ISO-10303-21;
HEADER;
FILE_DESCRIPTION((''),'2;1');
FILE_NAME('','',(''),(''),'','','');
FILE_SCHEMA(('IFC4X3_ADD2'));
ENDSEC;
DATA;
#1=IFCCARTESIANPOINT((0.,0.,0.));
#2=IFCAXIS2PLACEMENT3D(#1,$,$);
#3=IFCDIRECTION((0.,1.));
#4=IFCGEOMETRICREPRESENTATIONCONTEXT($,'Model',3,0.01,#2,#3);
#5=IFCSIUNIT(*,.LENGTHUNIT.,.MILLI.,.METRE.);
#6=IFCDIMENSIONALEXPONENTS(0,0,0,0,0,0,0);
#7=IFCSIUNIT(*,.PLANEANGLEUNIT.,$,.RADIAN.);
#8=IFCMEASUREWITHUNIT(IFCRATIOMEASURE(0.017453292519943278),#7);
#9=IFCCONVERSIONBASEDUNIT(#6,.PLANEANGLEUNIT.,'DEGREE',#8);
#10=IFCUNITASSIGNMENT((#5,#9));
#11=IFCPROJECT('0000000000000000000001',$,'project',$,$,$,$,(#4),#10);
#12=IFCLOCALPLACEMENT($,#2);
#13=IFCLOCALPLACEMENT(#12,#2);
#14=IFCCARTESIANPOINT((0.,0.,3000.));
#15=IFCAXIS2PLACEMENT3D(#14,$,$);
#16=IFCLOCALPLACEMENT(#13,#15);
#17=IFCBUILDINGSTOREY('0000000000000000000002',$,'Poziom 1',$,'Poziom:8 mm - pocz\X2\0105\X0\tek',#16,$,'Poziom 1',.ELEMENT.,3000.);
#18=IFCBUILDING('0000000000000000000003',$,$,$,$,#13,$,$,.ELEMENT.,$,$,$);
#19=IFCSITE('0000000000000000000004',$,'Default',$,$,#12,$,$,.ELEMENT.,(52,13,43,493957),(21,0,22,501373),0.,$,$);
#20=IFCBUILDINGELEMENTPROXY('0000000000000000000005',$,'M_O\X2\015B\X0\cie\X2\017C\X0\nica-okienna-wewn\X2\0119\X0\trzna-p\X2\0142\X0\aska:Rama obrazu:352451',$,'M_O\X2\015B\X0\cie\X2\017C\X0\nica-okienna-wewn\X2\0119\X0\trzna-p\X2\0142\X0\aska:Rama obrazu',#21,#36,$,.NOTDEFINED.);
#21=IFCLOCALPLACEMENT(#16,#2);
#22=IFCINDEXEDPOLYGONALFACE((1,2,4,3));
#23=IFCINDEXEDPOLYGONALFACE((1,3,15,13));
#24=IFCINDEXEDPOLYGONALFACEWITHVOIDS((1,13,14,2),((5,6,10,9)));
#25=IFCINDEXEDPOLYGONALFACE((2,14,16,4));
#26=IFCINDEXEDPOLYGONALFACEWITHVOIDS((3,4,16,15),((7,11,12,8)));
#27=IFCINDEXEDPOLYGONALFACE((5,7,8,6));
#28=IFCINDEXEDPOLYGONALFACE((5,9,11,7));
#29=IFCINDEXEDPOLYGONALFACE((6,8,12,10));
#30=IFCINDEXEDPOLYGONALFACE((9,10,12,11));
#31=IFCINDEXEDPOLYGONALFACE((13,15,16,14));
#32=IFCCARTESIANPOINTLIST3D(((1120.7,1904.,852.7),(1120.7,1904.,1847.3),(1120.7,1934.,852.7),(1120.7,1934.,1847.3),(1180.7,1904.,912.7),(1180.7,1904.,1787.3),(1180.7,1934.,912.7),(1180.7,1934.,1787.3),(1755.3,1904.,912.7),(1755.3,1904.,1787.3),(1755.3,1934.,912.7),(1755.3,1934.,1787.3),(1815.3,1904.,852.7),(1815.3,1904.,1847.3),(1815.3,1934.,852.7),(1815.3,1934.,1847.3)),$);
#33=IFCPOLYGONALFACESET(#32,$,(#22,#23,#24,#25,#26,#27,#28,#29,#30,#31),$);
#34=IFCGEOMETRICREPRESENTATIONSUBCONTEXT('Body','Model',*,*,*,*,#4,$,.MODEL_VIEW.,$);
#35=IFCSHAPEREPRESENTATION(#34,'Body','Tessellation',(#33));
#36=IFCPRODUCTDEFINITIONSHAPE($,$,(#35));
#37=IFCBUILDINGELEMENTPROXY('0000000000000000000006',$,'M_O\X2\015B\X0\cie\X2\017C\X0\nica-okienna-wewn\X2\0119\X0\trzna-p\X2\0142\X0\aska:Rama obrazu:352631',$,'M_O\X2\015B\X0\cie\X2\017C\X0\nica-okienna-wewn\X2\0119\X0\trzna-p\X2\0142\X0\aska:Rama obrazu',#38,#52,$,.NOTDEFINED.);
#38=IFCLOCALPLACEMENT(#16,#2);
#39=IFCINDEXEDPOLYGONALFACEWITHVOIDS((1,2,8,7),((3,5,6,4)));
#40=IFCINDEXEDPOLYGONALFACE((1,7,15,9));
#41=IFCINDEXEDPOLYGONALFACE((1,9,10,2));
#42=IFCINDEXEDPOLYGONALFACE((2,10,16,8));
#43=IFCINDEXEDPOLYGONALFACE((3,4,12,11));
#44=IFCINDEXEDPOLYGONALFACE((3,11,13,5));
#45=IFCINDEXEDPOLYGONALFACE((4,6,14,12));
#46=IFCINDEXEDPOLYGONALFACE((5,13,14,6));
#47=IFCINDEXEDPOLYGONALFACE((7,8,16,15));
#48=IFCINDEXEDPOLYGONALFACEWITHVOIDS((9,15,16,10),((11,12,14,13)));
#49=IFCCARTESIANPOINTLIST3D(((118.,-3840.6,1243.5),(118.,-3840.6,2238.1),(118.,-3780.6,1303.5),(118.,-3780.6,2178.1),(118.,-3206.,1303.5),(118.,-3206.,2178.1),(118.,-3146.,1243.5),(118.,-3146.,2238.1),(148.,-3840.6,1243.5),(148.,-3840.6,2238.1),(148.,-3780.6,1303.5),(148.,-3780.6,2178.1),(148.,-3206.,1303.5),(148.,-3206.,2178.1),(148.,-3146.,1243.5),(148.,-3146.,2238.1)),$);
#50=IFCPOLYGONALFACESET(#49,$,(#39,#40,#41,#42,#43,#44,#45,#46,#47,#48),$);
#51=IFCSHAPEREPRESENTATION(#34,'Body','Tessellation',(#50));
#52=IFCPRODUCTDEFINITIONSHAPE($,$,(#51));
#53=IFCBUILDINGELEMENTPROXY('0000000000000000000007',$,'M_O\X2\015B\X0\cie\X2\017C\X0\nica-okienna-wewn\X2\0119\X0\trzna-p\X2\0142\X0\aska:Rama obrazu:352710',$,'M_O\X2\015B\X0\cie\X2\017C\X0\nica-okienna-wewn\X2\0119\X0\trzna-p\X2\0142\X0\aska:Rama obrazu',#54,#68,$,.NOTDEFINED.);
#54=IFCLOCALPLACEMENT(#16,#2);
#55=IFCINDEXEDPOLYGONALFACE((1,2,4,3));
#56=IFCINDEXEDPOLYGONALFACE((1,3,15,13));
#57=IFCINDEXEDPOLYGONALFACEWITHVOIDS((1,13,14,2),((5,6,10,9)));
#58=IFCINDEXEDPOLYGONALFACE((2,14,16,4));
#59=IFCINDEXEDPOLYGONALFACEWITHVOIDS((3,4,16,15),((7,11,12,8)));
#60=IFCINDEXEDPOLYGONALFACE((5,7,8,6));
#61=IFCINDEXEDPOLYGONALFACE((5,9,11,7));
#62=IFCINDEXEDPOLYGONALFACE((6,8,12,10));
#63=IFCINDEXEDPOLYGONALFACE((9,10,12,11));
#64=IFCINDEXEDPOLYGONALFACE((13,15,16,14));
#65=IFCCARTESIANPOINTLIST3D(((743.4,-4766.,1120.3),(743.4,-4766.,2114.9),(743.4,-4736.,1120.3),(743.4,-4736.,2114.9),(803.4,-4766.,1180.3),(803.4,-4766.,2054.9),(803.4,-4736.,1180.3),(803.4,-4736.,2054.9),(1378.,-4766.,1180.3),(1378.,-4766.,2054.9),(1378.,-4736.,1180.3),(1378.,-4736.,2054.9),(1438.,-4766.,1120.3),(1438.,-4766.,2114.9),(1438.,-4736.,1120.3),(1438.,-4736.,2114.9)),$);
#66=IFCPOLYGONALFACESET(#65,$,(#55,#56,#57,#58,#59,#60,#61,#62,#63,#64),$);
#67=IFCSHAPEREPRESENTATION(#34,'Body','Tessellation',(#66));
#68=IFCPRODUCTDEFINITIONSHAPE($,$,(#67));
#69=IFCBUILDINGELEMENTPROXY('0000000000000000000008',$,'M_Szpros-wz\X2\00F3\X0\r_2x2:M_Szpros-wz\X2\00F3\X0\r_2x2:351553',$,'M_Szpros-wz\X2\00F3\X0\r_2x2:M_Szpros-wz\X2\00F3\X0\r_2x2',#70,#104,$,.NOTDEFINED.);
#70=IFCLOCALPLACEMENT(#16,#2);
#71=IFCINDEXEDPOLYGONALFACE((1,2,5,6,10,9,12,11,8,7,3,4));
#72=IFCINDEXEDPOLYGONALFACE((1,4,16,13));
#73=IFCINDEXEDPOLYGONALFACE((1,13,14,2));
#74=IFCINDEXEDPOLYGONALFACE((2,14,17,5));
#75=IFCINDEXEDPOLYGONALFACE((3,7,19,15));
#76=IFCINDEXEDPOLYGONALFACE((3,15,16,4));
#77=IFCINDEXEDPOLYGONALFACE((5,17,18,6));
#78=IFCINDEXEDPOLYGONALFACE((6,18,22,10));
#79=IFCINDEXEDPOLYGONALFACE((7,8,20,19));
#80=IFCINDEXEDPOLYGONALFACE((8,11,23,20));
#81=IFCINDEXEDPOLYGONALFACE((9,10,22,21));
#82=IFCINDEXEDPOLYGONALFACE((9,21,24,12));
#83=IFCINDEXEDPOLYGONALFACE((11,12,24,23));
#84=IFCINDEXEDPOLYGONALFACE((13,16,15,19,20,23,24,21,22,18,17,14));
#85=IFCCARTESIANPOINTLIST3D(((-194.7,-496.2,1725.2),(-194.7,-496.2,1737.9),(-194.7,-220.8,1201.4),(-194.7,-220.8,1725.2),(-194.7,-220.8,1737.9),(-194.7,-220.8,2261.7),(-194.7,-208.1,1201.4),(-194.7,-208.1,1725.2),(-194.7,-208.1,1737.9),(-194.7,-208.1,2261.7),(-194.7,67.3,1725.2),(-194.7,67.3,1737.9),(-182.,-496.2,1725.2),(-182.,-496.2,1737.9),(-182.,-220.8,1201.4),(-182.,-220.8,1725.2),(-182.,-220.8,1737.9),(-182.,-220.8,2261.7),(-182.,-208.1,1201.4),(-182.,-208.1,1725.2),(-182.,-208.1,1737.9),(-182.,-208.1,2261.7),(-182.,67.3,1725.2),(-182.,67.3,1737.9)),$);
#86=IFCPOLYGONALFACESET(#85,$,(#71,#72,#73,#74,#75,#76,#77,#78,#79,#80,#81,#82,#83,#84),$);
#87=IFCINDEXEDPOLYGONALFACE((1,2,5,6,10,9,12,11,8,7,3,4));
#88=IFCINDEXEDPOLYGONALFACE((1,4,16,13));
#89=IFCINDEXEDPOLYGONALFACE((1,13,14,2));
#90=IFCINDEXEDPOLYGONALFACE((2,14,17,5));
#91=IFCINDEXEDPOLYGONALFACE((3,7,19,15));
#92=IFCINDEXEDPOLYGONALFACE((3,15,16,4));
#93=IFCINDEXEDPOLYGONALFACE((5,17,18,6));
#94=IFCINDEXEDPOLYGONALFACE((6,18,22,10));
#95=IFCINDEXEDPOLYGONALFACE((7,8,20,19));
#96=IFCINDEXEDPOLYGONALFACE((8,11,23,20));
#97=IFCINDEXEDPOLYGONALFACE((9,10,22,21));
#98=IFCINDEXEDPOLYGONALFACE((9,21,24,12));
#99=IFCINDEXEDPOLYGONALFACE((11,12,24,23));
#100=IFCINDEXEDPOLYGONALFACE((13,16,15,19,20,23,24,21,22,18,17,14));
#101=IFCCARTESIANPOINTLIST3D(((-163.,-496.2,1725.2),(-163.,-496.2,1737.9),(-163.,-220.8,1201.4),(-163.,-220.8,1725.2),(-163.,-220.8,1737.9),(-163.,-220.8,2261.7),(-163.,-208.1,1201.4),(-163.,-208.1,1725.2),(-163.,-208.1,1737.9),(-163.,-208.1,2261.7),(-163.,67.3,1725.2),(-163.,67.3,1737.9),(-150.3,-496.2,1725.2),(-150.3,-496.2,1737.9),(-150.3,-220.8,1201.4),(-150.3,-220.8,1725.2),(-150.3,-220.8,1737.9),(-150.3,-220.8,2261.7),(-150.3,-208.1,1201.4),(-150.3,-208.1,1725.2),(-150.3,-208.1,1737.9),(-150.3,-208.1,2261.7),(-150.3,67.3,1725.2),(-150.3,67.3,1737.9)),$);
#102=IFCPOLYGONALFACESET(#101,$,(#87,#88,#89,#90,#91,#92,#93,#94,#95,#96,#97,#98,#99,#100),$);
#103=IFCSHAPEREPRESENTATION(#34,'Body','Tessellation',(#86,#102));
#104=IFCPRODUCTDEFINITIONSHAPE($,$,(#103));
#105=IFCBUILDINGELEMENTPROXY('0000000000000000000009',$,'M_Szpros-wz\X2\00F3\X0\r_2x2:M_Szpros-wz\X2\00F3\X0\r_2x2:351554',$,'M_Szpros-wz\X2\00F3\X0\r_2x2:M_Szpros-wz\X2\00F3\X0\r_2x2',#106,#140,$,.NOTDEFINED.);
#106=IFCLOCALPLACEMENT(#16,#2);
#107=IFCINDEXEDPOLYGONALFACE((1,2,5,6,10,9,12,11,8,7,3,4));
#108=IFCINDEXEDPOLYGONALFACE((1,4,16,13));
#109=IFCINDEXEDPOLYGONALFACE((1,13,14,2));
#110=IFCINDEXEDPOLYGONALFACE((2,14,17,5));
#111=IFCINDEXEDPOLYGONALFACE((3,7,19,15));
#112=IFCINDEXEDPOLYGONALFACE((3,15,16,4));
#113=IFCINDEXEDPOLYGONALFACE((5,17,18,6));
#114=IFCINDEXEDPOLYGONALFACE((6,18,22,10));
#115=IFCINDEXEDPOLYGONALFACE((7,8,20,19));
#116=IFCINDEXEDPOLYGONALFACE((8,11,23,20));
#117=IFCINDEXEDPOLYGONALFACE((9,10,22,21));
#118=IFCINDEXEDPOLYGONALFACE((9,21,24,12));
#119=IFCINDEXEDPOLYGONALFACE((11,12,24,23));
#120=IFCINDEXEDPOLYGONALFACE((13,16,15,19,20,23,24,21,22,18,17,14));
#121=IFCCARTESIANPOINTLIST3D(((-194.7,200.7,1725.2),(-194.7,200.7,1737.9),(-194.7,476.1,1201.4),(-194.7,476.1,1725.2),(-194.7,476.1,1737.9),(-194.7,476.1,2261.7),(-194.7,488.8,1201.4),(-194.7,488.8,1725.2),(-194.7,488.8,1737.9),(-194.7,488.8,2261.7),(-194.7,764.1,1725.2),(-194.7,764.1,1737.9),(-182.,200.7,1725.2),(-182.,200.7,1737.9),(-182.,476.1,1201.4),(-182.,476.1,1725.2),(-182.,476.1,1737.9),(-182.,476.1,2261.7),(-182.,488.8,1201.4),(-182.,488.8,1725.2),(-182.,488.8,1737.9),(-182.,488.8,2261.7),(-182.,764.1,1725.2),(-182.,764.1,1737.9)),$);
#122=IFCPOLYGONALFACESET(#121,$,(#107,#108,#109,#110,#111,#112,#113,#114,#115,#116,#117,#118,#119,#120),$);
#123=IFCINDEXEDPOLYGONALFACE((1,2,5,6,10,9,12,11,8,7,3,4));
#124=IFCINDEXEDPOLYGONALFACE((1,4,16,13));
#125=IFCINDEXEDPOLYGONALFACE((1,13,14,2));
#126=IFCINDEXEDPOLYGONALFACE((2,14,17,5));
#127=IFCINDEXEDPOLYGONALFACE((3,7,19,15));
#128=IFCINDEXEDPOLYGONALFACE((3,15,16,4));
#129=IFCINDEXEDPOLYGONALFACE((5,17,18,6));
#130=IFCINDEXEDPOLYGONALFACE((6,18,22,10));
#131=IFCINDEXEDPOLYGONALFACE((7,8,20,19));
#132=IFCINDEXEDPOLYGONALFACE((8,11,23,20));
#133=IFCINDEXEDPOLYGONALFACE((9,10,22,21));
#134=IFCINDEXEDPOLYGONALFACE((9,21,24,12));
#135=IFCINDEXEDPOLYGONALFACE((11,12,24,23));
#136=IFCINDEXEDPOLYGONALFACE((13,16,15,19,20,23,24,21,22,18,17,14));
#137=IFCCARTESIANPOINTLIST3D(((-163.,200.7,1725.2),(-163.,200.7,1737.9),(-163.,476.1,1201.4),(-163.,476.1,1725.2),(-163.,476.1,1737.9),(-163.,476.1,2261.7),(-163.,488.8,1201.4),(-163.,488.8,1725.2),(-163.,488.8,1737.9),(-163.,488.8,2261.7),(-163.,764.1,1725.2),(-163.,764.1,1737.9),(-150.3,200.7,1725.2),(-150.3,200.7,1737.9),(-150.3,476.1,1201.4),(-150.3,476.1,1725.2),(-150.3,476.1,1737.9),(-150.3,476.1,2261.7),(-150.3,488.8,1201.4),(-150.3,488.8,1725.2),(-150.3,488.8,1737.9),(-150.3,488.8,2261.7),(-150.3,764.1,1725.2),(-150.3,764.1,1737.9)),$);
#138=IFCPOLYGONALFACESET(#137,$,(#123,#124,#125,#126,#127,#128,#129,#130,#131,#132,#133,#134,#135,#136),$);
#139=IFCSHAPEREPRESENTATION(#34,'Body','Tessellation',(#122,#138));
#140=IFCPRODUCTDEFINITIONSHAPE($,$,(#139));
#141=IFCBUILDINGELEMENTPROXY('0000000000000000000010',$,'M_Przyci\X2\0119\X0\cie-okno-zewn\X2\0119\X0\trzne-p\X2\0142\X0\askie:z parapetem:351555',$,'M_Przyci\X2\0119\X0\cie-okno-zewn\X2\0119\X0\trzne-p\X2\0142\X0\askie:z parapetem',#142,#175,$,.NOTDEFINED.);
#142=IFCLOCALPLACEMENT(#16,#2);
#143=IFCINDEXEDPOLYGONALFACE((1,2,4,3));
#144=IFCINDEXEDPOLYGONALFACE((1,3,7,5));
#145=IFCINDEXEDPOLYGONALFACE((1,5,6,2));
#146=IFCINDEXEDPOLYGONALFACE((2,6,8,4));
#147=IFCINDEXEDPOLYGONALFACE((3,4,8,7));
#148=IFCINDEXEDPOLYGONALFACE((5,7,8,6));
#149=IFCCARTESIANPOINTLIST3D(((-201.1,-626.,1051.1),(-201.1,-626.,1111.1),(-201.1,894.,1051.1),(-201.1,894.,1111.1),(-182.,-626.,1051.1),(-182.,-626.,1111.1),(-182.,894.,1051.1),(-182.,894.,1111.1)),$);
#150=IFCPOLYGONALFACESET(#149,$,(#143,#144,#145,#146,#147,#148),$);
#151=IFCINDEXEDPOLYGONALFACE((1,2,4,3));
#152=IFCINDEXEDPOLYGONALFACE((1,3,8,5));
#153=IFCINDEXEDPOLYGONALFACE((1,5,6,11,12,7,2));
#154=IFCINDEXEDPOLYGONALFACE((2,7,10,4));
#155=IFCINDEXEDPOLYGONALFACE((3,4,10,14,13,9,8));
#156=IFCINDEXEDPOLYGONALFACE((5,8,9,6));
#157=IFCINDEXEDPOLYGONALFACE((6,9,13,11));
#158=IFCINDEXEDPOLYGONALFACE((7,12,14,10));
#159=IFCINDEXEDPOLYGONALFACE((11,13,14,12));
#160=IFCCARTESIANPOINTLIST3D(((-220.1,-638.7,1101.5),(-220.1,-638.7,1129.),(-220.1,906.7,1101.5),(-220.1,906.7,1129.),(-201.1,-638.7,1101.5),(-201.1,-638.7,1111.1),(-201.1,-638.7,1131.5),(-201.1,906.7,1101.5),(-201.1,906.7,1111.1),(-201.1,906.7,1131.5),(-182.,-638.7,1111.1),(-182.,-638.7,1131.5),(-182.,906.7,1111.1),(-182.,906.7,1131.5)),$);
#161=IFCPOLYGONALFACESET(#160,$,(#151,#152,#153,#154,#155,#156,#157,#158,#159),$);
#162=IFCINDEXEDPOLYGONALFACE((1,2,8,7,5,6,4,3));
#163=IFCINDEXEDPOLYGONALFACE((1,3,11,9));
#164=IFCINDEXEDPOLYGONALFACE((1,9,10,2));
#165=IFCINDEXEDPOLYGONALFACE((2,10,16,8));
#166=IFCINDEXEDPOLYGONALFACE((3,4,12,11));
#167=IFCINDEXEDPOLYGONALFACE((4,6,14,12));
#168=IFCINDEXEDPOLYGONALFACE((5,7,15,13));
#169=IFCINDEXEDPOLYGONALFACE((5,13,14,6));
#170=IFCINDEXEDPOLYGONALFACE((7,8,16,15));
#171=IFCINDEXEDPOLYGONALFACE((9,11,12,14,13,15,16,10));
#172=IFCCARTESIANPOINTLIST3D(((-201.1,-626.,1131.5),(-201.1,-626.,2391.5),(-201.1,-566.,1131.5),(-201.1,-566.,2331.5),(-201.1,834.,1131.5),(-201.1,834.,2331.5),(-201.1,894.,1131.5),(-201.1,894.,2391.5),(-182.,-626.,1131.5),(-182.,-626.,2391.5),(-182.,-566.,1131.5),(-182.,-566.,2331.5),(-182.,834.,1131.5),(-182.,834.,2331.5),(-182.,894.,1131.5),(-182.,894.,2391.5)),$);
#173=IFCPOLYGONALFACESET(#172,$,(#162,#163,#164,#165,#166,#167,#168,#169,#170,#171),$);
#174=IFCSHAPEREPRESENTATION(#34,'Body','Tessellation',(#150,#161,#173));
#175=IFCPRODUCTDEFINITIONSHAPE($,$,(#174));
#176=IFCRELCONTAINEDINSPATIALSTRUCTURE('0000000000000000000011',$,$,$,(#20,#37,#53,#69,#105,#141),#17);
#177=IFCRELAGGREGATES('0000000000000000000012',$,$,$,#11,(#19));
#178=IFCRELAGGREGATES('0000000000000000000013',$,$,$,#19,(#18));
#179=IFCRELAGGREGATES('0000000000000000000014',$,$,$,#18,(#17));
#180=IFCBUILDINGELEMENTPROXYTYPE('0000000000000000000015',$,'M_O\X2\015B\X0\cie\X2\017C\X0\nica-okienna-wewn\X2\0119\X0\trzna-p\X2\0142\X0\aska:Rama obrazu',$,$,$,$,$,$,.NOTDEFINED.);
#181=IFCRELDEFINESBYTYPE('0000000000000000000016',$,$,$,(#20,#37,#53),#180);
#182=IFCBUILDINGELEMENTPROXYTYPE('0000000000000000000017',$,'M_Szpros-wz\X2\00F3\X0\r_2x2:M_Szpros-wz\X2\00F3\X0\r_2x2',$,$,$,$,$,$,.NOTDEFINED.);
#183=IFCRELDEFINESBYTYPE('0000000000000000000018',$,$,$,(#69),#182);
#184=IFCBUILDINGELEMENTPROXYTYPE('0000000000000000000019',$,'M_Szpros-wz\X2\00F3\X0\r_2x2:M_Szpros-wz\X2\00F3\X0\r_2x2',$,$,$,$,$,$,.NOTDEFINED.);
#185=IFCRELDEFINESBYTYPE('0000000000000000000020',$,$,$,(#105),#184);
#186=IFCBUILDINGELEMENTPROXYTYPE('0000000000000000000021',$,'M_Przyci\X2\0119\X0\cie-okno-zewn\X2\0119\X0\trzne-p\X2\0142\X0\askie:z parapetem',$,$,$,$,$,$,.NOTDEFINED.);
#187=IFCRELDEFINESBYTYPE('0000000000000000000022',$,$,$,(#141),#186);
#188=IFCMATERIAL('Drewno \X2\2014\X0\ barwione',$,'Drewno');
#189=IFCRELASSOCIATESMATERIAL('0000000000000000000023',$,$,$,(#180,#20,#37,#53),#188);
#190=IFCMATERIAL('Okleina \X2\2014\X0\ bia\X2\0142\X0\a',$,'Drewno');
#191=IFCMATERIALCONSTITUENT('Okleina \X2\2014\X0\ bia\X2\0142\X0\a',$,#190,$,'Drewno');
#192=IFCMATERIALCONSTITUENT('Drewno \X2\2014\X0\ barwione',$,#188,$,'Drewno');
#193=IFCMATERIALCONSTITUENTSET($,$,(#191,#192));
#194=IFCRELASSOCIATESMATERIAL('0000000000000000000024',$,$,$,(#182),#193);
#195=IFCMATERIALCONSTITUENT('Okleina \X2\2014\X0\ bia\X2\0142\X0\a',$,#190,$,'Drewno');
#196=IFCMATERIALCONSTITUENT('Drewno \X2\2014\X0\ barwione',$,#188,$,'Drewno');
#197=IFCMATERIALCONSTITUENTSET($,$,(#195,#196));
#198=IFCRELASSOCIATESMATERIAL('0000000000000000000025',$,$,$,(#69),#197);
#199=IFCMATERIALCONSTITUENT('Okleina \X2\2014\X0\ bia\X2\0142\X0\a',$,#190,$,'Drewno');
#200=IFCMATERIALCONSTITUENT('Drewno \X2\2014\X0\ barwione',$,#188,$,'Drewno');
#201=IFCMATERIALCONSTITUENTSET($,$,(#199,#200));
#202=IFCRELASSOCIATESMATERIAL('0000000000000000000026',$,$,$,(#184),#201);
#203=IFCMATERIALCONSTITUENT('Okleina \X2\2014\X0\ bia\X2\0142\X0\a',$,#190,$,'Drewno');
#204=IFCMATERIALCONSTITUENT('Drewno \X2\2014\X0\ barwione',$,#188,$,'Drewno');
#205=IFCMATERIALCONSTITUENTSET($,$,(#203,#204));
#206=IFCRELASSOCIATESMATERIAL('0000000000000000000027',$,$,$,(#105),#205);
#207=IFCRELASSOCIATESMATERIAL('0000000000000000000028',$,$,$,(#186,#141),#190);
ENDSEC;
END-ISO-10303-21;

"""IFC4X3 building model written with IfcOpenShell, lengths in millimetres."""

from ifc_helpers import new_model, entity, si_unit, converted_unit, direction, frame, frame_2d, origin, place, context, subcontext, project, spatial, polyline, rectangle, outline, extrude, source, transform, mapped, material, constituent, constituent_set, type_object, type_shapes, element, save


model = new_model("IFC4X3")

# Units and contexts
model_context = context("Model", 3, precision=0.01, world=origin(), true_north=direction((0.0, 1.0)))
body_context = subcontext(model_context, "Body", "Model", "MODEL_VIEW")
ifc_project = project(units=[si_unit("LENGTHUNIT", "METRE", prefix="MILLI"), converted_unit("PLANEANGLEUNIT", "DEGREE", entity("IfcRatioMeasure", 0.017453292519943278), si_unit("PLANEANGLEUNIT", "RADIAN"), dimensions=[0, 0, 0, 0, 0, 0, 0])], contexts=[model_context])

# Site, building, storey
site_placement = place(None, origin())
site = spatial("IfcSite", under=ifc_project, at=site_placement, Name="Default", CompositionType="ELEMENT", RefLatitude=(52, 13, 43, 493957), RefLongitude=(21, 0, 22, 501373), RefElevation=0.0)
building_placement = place(site_placement, origin())
building = spatial("IfcBuilding", under=site, at=building_placement, CompositionType="ELEMENT")
storey_placement = place(building_placement, frame((0.0, 0.0, 3000.0)))
storey = spatial("IfcBuildingStorey", under=building, at=storey_placement, Name="Poziom 1", ObjectType="Poziom:8 mm - początek", LongName="Poziom 1", CompositionType="ELEMENT", Elevation=3000.0)

# Building element proxies
ifc_material_1 = material(Name="Okleina — biała", Category="Drewno")
ifc_material_2 = material(Name="Drewno — barwione", Category="Drewno")
building_element_proxy_type_1 = type_object("IfcBuildingElementProxyType", Name="M_Ościeżnica-okienna-wewnętrzna-płaska:Rama obrazu", PredefinedType="NOTDEFINED", material=ifc_material_2)
shared_shape_1 = source(origin(), body_context, "Body", "SweptSolid", [
    extrude(outline(polyline([(-347.3, -497.3), (347.3, -497.3), (347.3, 497.3), (-347.3, 497.3), (-347.3, -497.3)]), holes=[polyline([(-287.3, -437.3), (-287.3, 437.3), (287.3, 437.3), (287.3, -437.3), (-287.3, -437.3)])]), frame((0.0, -450.0, 0.0), z_axis=(0.0, 0.0, 1.0), x_axis=(-1.0, 0.0, 0.0)), (0.0, 0.0, 1.0), 30.0),
])
type_shapes(building_element_proxy_type_1, [shared_shape_1])
for number, where, z_axis, x_axis, name in (
    (1, (1468.0, 1934.0, 1800.0), (0.0, -1.0, 0.0), (1.0, 0.0, 0.0), "M_Ościeżnica-okienna-wewnętrzna-płaska:Rama obrazu:352451"),
    (2, (118.0, -3493.3, 2190.8), (1.0, 0.0, 0.0), (0.0, 1.0, 0.0), "M_Ościeżnica-okienna-wewnętrzna-płaska:Rama obrazu:352631"),
    (3, (1090.7, -4766.0, 2067.6), (0.0, 1.0, 0.0), (-1.0, 0.0, 0.0), "M_Ościeżnica-okienna-wewnętrzna-płaska:Rama obrazu:352710"),
):
    element("IfcBuildingElementProxy", number, at=place(storey_placement, frame(where, z_axis=z_axis, x_axis=x_axis)), inside=storey, type_object=building_element_proxy_type_1, material=ifc_material_2, Name=name, ObjectType="M_Ościeżnica-okienna-wewnętrzna-płaska:Rama obrazu", PredefinedType="NOTDEFINED", context=body_context, shape_type="MappedRepresentation", body=[
        mapped(shared_shape_1, transform((0.0, 0.0, 0.0), scale=1.0)),
    ])
ifc_constituent_1 = constituent(ifc_material_1, Name="Okleina — biała", Category="Drewno")
ifc_constituent_2 = constituent(ifc_material_2, Name="Drewno — barwione", Category="Drewno")
ifc_constituent_set_1 = constituent_set(constituents=[ifc_constituent_1, ifc_constituent_2])
ifc_constituent_3 = constituent(ifc_material_1, Name="Okleina — biała", Category="Drewno")
ifc_constituent_4 = constituent(ifc_material_2, Name="Drewno — barwione", Category="Drewno")
ifc_constituent_set_2 = constituent_set(constituents=[ifc_constituent_3, ifc_constituent_4])
building_element_proxy_type_2 = type_object("IfcBuildingElementProxyType", Name="M_Szpros-wzór_2x2:M_Szpros-wzór_2x2", PredefinedType="NOTDEFINED", material=ifc_constituent_set_2)
shared_shape_2 = source(origin(), body_context, "Body", "SweptSolid", [
    extrude(outline(polyline([(6.4, -6.4), (530.1, -6.4), (530.1, 6.3), (6.4, 6.3), (6.4, 281.7), (-6.3, 281.7), (-6.3, 6.3), (-530.2, 6.3), (-530.2, -6.4), (-6.3, -6.4), (-6.3, -281.7), (6.4, -281.7), (6.4, -6.4)])), frame((0.0, 9.5, 530.1), z_axis=(0.0, 1.0, 0.0), x_axis=(0.0, 0.0, 1.0)), (0.0, 0.0, 1.0), 12.7),
    extrude(outline(polyline([(6.4, -6.4), (530.2, -6.4), (530.2, 6.3), (6.4, 6.3), (6.4, 281.7), (-6.3, 281.7), (-6.3, 6.3), (-530.2, 6.3), (-530.2, -6.4), (-6.3, -6.4), (-6.3, -281.7), (6.4, -281.7), (6.4, -6.4)])), frame((0.0, -22.2, 530.2), z_axis=(0.0, 1.0, 0.0), x_axis=(0.0, 0.0, 1.0)), (0.0, 0.0, 1.0), 12.7),
])
type_shapes(building_element_proxy_type_2, [shared_shape_2])
proxy_1_placement = place(storey_placement, frame((-172.5, -214.4, 1201.4), z_axis=(0.0, 0.0, 1.0), x_axis=(0.0, 1.0, 0.0)))
element("IfcBuildingElementProxy", 4, at=proxy_1_placement, inside=storey, type_object=building_element_proxy_type_2, material=ifc_constituent_set_1, Name="M_Szpros-wzór_2x2:M_Szpros-wzór_2x2:351553", ObjectType="M_Szpros-wzór_2x2:M_Szpros-wzór_2x2", PredefinedType="NOTDEFINED", context=body_context, shape_type="MappedRepresentation", body=[
    mapped(shared_shape_2, transform((0.0, 0.0, 0.0), scale=1.0)),
])
ifc_constituent_5 = constituent(ifc_material_1, Name="Okleina — biała", Category="Drewno")
ifc_constituent_6 = constituent(ifc_material_2, Name="Drewno — barwione", Category="Drewno")
ifc_constituent_set_3 = constituent_set(constituents=[ifc_constituent_5, ifc_constituent_6])
ifc_constituent_7 = constituent(ifc_material_1, Name="Okleina — biała", Category="Drewno")
ifc_constituent_8 = constituent(ifc_material_2, Name="Drewno — barwione", Category="Drewno")
ifc_constituent_set_4 = constituent_set(constituents=[ifc_constituent_7, ifc_constituent_8])
building_element_proxy_type_3 = type_object("IfcBuildingElementProxyType", Name="M_Szpros-wzór_2x2:M_Szpros-wzór_2x2", PredefinedType="NOTDEFINED", material=ifc_constituent_set_4)
shared_shape_3 = source(origin(), body_context, "Body", "SweptSolid", [
    extrude(outline(polyline([(6.4, -6.4), (530.1, -6.4), (530.1, 6.3), (6.4, 6.3), (6.4, 281.7), (-6.3, 281.7), (-6.3, 6.3), (-530.2, 6.3), (-530.2, -6.4), (-6.3, -6.4), (-6.3, -281.7), (6.4, -281.7), (6.4, -6.4)])), frame((0.0, -22.2, 530.1), z_axis=(0.0, 1.0, 0.0), x_axis=(0.0, 0.0, 1.0)), (0.0, 0.0, 1.0), 12.7),
    extrude(outline(polyline([(6.4, -6.4), (530.2, -6.4), (530.2, 6.3), (6.4, 6.3), (6.4, 281.7), (-6.3, 281.7), (-6.3, 6.3), (-530.2, 6.3), (-530.2, -6.4), (-6.3, -6.4), (-6.3, -281.7), (6.4, -281.7), (6.4, -6.4)])), frame((0.0, 9.5, 530.2), z_axis=(0.0, 1.0, 0.0), x_axis=(0.0, 0.0, 1.0)), (0.0, 0.0, 1.0), 12.7),
])
type_shapes(building_element_proxy_type_3, [shared_shape_3])
proxy_2_placement = place(storey_placement, frame((-172.5, 482.4, 1201.4), z_axis=(0.0, 0.0, 1.0), x_axis=(0.0, -1.0, 0.0)))
element("IfcBuildingElementProxy", 5, at=proxy_2_placement, inside=storey, type_object=building_element_proxy_type_3, material=ifc_constituent_set_3, Name="M_Szpros-wzór_2x2:M_Szpros-wzór_2x2:351554", ObjectType="M_Szpros-wzór_2x2:M_Szpros-wzór_2x2", PredefinedType="NOTDEFINED", context=body_context, shape_type="MappedRepresentation", body=[
    mapped(shared_shape_3, transform((0.0, 0.0, 0.0), scale=1.0)),
])
building_element_proxy_type_4 = type_object("IfcBuildingElementProxyType", Name="M_Przycięcie-okno-zewnętrzne-płaskie:z parapetem", PredefinedType="NOTDEFINED", material=ifc_material_1)
shared_shape_4 = source(origin(), body_context, "Body", "SweptSolid", [
    extrude(rectangle(XDim=1520.0, YDim=60.0, at=frame_2d((0.0, 0.0), x_axis=(1.0, 0.0))), frame((0.0, -1250.4, 0.0), z_axis=(0.0, 0.0, 1.0), x_axis=(-1.0, 0.0, 0.0)), (0.0, 0.0, 1.0), 19.0),
    extrude(outline(polyline([(-19.0, -15.2), (0.0, -15.2), (0.0, -5.7), (19.0, -5.7), (19.0, 14.8), (0.0, 14.8), (-19.0, 12.3), (-19.0, -15.2)])), frame((-772.7, -1214.8, 19.0), z_axis=(1.0, 0.0, 0.0), x_axis=(0.0, 0.0, -1.0)), (0.0, 0.0, 1.0), 1545.4),
    extrude(outline(polyline([(-645.0, -760.0), (615.0, -760.0), (615.0, -700.0), (-585.0, -700.0), (-585.0, 700.0), (615.0, 700.0), (615.0, 760.0), (-645.0, 760.0), (-645.0, -760.0)])), frame((0.0, -585.0, 0.0), z_axis=(0.0, 0.0, 1.0), x_axis=(0.0, -1.0, 0.0)), (0.0, 0.0, 1.0), 19.0),
])
type_shapes(building_element_proxy_type_4, [shared_shape_4])
proxy_3_placement = place(storey_placement, frame((-182.0, 134.0, 2331.5), z_axis=(-1.0, 0.0, 0.0), x_axis=(0.0, -1.0, 0.0)))
element("IfcBuildingElementProxy", 6, at=proxy_3_placement, inside=storey, type_object=building_element_proxy_type_4, material=ifc_material_1, Name="M_Przycięcie-okno-zewnętrzne-płaskie:z parapetem:351555", ObjectType="M_Przycięcie-okno-zewnętrzne-płaskie:z parapetem", PredefinedType="NOTDEFINED", context=body_context, shape_type="MappedRepresentation", body=[
    mapped(shared_shape_4, transform((0.0, 0.0, 0.0), scale=1.0)),
])

save(model, "model.ifc")
